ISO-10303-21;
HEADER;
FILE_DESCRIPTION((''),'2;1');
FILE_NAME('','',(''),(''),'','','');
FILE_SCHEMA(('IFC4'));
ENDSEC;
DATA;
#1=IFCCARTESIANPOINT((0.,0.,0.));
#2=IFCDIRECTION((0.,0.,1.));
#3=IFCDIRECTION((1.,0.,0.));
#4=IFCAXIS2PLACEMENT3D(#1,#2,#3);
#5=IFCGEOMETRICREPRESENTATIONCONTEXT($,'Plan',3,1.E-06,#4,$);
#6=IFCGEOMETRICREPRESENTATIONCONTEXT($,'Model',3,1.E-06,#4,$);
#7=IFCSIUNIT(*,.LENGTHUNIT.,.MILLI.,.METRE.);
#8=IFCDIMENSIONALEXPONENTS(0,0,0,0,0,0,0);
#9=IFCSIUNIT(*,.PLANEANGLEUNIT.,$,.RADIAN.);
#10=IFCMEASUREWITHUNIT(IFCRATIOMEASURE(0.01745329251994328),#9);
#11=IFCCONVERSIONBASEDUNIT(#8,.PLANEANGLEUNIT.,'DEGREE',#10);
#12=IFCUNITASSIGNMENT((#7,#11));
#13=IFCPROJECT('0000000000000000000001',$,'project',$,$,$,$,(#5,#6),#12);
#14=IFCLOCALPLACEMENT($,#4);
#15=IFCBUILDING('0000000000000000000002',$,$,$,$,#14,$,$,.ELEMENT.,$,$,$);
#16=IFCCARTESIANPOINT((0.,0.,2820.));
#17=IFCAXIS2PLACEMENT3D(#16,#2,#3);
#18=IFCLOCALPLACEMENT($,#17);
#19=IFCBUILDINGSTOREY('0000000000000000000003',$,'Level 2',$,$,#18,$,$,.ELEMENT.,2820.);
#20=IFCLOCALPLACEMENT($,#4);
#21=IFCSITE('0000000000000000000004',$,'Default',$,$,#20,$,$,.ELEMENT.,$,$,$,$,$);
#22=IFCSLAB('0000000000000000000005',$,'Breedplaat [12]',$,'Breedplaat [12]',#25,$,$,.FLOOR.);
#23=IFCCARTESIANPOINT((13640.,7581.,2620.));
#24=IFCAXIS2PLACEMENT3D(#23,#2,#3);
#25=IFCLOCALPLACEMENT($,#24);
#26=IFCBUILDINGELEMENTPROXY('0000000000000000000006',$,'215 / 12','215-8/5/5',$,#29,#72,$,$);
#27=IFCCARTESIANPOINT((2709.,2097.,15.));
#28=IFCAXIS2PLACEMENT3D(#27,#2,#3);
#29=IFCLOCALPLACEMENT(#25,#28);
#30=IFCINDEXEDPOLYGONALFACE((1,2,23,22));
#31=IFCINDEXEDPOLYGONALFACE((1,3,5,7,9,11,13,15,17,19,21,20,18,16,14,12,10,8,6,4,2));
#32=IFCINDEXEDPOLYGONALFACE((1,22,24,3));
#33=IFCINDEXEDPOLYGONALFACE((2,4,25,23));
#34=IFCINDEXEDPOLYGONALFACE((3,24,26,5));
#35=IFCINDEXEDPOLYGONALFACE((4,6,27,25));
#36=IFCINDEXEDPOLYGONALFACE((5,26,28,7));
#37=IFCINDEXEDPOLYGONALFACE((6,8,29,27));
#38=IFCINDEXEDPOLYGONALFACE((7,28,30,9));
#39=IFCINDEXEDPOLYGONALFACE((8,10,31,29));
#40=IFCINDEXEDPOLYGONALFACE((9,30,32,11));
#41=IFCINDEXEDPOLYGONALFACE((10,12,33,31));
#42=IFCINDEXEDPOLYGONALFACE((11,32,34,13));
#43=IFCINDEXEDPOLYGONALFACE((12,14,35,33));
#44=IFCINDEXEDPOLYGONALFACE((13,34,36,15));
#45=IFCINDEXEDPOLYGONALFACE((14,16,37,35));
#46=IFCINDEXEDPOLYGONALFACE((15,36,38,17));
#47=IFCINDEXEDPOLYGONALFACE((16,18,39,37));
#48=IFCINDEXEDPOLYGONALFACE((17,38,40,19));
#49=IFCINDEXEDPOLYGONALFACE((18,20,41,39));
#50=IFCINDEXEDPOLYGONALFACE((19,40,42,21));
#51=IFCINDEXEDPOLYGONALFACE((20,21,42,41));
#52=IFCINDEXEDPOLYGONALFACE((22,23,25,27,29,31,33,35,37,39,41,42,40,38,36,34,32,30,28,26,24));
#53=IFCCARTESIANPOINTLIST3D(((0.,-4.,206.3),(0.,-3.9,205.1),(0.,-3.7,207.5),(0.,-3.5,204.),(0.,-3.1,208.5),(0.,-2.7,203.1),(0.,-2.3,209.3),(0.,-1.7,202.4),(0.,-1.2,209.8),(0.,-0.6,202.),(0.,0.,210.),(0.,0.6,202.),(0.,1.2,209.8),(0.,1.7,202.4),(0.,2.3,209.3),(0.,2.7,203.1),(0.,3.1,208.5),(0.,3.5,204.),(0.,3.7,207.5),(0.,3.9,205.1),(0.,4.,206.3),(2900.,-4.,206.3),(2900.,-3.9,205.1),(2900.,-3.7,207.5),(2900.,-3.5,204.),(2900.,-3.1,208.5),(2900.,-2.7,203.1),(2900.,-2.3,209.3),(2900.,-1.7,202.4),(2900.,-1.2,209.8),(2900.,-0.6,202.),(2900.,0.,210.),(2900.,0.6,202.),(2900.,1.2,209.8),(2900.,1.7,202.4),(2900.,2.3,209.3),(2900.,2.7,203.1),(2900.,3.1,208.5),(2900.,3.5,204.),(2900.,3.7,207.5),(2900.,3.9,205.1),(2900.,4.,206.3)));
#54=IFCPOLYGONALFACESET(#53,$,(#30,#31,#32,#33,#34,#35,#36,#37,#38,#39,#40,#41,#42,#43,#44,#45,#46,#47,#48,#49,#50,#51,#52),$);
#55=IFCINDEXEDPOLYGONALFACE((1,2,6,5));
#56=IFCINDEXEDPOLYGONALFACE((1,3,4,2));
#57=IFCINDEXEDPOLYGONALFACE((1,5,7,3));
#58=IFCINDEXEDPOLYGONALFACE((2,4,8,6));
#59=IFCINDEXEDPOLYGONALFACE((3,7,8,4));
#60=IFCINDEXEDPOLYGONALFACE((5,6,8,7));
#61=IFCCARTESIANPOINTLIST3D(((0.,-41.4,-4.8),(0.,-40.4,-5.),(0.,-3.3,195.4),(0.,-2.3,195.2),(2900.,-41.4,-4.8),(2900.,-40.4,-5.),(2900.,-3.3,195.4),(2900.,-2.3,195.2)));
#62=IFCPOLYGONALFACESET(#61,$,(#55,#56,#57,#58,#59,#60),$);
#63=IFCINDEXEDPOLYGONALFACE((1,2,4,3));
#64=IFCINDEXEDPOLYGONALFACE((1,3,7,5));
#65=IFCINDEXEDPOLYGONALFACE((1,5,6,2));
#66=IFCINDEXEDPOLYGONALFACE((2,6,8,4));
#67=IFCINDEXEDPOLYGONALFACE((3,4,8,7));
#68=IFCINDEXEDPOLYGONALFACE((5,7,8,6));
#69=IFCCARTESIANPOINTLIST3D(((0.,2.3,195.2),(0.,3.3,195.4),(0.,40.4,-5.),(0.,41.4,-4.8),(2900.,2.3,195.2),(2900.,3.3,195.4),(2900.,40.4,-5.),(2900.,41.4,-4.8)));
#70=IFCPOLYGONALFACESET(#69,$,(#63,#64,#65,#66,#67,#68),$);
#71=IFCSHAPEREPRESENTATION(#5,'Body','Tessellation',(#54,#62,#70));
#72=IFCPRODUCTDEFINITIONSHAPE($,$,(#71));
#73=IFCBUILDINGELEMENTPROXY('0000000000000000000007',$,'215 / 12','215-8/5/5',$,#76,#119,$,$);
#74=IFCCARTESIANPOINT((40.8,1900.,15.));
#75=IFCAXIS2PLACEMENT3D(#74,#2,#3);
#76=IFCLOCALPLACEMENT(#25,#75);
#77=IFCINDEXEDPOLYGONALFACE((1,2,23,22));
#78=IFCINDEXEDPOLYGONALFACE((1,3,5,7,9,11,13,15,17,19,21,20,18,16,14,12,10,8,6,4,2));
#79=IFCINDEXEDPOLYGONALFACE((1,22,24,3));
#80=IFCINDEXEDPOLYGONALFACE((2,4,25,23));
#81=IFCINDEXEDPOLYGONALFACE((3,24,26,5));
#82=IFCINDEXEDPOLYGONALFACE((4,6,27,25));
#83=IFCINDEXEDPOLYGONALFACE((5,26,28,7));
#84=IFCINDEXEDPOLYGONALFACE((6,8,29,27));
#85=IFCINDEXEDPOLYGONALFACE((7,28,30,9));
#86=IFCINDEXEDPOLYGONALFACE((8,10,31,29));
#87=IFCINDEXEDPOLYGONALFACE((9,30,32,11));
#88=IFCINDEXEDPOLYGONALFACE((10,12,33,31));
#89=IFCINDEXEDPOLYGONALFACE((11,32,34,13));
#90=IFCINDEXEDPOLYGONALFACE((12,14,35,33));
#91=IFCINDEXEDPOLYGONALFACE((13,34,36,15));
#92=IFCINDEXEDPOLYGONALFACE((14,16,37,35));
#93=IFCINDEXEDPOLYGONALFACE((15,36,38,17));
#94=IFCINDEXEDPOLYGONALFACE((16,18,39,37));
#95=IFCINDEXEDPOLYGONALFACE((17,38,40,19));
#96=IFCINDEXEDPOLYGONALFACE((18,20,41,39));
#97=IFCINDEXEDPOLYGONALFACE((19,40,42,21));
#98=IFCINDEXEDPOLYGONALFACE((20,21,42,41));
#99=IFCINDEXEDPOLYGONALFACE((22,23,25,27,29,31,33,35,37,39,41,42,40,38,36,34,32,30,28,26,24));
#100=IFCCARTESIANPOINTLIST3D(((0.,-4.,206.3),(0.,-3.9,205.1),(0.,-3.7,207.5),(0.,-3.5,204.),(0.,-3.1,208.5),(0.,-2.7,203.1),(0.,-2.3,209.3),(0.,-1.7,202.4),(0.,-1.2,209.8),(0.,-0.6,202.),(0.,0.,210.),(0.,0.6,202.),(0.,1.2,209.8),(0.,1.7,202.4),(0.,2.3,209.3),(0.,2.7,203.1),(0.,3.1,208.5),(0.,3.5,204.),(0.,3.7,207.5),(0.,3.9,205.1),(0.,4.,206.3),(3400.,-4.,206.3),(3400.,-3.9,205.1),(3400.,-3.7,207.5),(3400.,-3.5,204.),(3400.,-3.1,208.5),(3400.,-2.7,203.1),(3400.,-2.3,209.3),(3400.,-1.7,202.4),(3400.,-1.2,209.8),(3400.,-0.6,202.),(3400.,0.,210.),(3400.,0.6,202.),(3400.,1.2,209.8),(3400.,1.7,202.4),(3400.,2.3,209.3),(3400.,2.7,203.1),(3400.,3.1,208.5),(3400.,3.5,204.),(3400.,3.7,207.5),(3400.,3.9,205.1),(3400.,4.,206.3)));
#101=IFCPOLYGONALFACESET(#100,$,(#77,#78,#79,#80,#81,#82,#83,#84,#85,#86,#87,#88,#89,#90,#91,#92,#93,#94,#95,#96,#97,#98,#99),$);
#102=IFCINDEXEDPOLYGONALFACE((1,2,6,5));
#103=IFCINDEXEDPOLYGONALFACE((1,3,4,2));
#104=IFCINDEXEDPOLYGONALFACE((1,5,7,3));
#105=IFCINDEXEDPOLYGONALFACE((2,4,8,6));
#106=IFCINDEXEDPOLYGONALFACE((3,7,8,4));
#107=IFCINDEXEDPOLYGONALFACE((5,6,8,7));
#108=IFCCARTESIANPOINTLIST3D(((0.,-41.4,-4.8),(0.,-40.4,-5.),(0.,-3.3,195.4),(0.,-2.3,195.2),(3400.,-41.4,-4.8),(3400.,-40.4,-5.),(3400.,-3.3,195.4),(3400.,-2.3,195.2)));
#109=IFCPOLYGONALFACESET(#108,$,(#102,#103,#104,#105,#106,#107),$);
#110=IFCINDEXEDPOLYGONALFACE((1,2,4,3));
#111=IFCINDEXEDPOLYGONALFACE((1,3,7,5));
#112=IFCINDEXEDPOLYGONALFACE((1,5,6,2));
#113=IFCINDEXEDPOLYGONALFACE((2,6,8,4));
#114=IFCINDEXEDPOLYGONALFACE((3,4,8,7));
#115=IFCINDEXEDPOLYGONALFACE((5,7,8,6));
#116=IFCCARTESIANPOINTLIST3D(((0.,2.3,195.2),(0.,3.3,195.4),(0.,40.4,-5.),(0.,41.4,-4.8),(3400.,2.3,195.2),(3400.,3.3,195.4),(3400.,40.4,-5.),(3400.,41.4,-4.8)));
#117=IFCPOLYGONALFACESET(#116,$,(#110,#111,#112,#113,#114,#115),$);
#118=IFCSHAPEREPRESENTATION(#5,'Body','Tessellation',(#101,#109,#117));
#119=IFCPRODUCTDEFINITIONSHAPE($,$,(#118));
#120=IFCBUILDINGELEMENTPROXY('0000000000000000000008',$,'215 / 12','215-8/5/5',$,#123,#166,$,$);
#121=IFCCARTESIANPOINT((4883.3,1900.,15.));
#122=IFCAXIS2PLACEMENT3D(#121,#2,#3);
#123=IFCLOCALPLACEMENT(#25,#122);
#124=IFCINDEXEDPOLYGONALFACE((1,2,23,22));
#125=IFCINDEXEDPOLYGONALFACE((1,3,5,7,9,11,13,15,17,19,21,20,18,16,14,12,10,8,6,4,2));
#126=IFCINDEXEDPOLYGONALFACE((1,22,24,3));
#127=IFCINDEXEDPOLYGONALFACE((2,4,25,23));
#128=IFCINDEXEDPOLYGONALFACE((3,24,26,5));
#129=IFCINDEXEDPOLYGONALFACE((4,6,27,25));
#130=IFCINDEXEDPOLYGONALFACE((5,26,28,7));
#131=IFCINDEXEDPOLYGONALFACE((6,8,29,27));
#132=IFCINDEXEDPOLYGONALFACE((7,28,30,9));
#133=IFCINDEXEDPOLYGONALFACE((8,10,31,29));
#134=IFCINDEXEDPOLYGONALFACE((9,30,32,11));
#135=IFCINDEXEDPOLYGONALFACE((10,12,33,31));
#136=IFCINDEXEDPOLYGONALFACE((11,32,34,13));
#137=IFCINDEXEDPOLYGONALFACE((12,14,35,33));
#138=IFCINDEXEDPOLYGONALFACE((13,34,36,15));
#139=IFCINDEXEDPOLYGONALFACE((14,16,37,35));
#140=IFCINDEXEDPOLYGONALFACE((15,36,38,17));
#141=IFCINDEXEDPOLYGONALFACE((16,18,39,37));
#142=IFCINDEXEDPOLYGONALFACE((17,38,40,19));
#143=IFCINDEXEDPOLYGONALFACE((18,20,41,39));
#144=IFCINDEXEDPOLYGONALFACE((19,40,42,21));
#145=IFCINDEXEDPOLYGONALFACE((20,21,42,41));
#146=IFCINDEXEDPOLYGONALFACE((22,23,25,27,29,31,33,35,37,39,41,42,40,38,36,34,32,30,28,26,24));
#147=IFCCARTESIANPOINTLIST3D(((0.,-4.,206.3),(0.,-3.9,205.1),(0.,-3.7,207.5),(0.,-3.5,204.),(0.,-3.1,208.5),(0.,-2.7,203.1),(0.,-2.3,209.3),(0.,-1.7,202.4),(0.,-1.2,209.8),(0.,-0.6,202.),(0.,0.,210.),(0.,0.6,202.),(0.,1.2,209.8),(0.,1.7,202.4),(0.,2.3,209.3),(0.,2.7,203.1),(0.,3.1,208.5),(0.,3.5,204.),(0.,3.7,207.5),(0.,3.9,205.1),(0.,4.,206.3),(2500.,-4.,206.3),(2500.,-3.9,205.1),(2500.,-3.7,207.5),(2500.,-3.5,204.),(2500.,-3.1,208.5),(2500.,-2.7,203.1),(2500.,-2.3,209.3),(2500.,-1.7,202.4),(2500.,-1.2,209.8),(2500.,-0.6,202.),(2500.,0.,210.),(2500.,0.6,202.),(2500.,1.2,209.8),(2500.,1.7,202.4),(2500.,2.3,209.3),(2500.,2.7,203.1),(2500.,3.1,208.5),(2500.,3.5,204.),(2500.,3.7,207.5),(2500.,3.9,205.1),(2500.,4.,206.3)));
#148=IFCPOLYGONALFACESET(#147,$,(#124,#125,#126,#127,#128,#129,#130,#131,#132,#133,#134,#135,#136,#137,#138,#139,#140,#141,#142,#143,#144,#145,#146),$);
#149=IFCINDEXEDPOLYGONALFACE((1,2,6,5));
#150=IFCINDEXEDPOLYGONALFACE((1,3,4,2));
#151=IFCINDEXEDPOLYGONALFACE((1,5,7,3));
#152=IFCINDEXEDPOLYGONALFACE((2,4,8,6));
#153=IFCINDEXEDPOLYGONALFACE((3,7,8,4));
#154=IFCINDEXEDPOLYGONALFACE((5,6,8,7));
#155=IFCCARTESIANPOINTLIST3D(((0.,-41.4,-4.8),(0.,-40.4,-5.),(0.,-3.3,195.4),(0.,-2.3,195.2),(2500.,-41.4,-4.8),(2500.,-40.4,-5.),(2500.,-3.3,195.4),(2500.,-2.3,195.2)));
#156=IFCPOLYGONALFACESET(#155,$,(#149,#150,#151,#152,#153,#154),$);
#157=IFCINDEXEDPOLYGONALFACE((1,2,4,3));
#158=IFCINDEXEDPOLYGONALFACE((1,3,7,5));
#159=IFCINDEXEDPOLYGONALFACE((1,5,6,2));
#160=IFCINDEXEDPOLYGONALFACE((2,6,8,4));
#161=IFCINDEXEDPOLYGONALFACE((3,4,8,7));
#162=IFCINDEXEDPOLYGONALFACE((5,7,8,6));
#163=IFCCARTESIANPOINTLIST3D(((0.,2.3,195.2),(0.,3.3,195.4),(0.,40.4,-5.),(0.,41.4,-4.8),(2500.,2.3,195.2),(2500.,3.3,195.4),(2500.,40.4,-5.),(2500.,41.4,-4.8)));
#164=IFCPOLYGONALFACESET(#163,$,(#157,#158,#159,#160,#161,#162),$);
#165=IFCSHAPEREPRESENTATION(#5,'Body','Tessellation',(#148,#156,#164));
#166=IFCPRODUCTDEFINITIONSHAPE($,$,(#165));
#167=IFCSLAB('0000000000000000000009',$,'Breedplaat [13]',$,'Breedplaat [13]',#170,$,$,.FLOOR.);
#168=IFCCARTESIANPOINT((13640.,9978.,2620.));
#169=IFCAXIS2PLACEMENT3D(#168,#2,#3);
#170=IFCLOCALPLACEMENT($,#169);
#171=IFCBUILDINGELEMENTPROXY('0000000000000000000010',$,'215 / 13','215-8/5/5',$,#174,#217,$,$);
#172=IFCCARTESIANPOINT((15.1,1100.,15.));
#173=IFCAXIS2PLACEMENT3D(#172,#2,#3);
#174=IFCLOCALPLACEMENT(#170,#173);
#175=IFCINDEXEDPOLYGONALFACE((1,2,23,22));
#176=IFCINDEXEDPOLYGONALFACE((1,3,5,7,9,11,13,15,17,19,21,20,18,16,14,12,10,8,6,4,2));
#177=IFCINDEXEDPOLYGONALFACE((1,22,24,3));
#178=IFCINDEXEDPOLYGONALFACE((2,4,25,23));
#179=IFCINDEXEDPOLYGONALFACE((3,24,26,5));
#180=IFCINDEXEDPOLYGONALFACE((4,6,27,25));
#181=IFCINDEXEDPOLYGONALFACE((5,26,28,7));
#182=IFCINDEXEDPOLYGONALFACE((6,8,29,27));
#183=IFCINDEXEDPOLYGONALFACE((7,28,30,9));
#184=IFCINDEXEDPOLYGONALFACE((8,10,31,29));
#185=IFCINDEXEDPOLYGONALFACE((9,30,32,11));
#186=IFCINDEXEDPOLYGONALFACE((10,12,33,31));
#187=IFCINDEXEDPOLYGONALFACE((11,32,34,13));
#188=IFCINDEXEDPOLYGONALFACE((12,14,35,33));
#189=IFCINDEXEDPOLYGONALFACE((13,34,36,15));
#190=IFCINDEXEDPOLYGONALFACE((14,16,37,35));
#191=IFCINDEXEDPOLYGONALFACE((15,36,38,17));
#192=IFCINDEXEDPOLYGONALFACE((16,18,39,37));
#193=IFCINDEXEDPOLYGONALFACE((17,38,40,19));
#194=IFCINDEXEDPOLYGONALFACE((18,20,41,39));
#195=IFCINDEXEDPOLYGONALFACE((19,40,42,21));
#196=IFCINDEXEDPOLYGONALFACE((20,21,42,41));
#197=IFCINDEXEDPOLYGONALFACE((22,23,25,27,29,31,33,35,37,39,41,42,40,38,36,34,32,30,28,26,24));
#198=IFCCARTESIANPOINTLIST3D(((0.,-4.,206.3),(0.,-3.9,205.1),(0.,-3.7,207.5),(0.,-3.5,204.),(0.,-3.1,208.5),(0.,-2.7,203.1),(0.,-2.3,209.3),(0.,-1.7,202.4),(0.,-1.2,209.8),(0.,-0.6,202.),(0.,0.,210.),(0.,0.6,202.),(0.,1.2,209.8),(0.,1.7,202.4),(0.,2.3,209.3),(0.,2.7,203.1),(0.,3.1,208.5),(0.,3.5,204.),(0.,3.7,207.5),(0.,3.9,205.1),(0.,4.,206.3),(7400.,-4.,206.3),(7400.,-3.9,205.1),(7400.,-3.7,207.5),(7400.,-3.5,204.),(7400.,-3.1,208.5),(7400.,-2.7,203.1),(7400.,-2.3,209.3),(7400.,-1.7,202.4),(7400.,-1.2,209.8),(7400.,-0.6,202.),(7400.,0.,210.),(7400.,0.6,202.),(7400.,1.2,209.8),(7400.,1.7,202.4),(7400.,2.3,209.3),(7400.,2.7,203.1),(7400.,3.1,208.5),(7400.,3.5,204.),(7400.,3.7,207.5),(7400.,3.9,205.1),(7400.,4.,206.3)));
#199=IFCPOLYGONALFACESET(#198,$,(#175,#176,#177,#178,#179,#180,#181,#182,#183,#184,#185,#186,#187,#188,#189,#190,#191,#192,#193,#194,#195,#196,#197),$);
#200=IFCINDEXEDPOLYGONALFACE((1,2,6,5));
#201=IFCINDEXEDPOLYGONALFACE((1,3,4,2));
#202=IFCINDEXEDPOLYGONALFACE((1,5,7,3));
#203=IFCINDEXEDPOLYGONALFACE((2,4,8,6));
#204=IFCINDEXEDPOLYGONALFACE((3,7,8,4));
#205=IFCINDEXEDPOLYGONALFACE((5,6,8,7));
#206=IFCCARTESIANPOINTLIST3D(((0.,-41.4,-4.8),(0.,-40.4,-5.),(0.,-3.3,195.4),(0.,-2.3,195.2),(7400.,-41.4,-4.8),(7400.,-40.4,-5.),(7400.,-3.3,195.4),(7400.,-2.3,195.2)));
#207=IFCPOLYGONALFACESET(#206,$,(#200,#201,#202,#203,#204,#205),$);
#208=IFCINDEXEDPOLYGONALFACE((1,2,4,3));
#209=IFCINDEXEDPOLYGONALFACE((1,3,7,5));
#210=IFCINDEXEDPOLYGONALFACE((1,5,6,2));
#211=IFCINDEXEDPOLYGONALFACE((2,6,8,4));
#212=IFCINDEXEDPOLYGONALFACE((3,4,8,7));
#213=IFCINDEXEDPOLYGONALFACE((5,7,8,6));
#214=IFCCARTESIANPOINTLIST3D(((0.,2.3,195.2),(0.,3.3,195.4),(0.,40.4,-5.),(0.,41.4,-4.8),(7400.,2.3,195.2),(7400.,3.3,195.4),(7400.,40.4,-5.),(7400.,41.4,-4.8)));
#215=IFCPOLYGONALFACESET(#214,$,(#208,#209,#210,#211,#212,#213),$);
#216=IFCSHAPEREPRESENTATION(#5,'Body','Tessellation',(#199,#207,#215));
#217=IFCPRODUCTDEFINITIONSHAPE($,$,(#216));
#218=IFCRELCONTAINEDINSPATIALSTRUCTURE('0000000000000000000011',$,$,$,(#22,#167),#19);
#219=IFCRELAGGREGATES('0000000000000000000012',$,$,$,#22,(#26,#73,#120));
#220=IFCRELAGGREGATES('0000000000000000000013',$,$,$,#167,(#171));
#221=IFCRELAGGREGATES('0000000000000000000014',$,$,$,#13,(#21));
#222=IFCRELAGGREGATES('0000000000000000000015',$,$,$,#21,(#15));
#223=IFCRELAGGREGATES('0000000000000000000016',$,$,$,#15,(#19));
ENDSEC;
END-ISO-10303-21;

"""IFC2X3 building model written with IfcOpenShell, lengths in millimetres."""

from ifc_helpers import new_model, entity, si_unit, converted_unit, frame, origin_with_axes, origin_2d_with_axis, place, context, project, spatial, rectangle, circle, extrude, element, aggregate, save


model = new_model("IFC2X3")

# Units and contexts
plan_context = context("Plan", 3, precision=1e-06, world=origin_with_axes())
model_context = context("Model", 3, precision=1e-06, world=origin_with_axes())
ifc_project = project(units=[si_unit("LENGTHUNIT", "METRE", prefix="MILLI"), converted_unit("PLANEANGLEUNIT", "DEGREE", entity("IfcRatioMeasure", 0.01745329251994328), si_unit("PLANEANGLEUNIT", "RADIAN"), dimensions=[0, 0, 0, 0, 0, 0, 0])], contexts=[plan_context, model_context])

# Site, building, storey
site_placement = place(None, origin_with_axes())
site = spatial("IfcSite", under=ifc_project, at=site_placement, Name="Default", CompositionType="ELEMENT")
building_placement = place(None, origin_with_axes())
building = spatial("IfcBuilding", under=site, at=building_placement, CompositionType="ELEMENT")
storey_placement = place(None, frame((0.0, 0.0, 2820.0), z_axis=(0.0, 0.0, 1.0), x_axis=(1.0, 0.0, 0.0)))
storey = spatial("IfcBuildingStorey", under=building, at=storey_placement, Name="Level 2", CompositionType="ELEMENT", Elevation=2820.0)

# Slab, building element proxies
slab_1_placement = place(None, frame((13640.0, 7581.0, 2620.0), z_axis=(0.0, 0.0, 1.0), x_axis=(1.0, 0.0, 0.0)))
slab_1 = element("IfcSlab", 1, at=slab_1_placement, inside=storey, Name="Breedplaat [12]", ObjectType="Breedplaat [12]", PredefinedType="FLOOR")
proxy_1_placement = place(slab_1_placement, frame((2709.0, 2097.0, 15.0), z_axis=(0.0, 0.0, 1.0), x_axis=(1.0, 0.0, 0.0)))
proxy_1 = element("IfcBuildingElementProxy", 2, at=proxy_1_placement, Name="215 / 12", Description="215-8/5/5", context=plan_context, shape_type="SweptSolid", body=[
    extrude(circle(Radius=4.0, at=origin_2d_with_axis()), frame((0.0, 0.0, 206.0), z_axis=(1.0, 0.0, 0.0), x_axis=(0.0, 0.0, 1.0)), (0.0, 0.0, 1.0), 2900.0),
    extrude(rectangle(XDim=203.8, YDim=1.0, at=origin_2d_with_axis()), frame((0.0, -21.9, 95.2), z_axis=(1.0, 0.0, 0.0), x_axis=(0.0, 0.187112, 0.982339)), (0.0, 0.0, 1.0), 2900.0),
    extrude(rectangle(XDim=203.8, YDim=1.0, at=origin_2d_with_axis()), frame((0.0, 21.9, 95.2), z_axis=(1.0, 0.0, 0.0), x_axis=(0.0, -0.187112, 0.982339)), (0.0, 0.0, 1.0), 2900.0),
])
proxy_2_placement = place(slab_1_placement, frame((40.8, 1900.0, 15.0), z_axis=(0.0, 0.0, 1.0), x_axis=(1.0, 0.0, 0.0)))
proxy_2 = element("IfcBuildingElementProxy", 3, at=proxy_2_placement, Name="215 / 12", Description="215-8/5/5", context=plan_context, shape_type="SweptSolid", body=[
    extrude(circle(Radius=4.0, at=origin_2d_with_axis()), frame((0.0, 0.0, 206.0), z_axis=(1.0, 0.0, 0.0), x_axis=(0.0, 0.0, 1.0)), (0.0, 0.0, 1.0), 3400.0),
    extrude(rectangle(XDim=203.8, YDim=1.0, at=origin_2d_with_axis()), frame((0.0, -21.9, 95.2), z_axis=(1.0, 0.0, 0.0), x_axis=(0.0, 0.187112, 0.982339)), (0.0, 0.0, 1.0), 3400.0),
    extrude(rectangle(XDim=203.8, YDim=1.0, at=origin_2d_with_axis()), frame((0.0, 21.9, 95.2), z_axis=(1.0, 0.0, 0.0), x_axis=(0.0, -0.187112, 0.982339)), (0.0, 0.0, 1.0), 3400.0),
])
proxy_3_placement = place(slab_1_placement, frame((4883.3, 1900.0, 15.0), z_axis=(0.0, 0.0, 1.0), x_axis=(1.0, 0.0, 0.0)))
proxy_3 = element("IfcBuildingElementProxy", 4, at=proxy_3_placement, Name="215 / 12", Description="215-8/5/5", context=plan_context, shape_type="SweptSolid", body=[
    extrude(circle(Radius=4.0, at=origin_2d_with_axis()), frame((0.0, 0.0, 206.0), z_axis=(1.0, 0.0, 0.0), x_axis=(0.0, 0.0, 1.0)), (0.0, 0.0, 1.0), 2500.0),
    extrude(rectangle(XDim=203.8, YDim=1.0, at=origin_2d_with_axis()), frame((0.0, -21.9, 95.2), z_axis=(1.0, 0.0, 0.0), x_axis=(0.0, 0.187112, 0.982339)), (0.0, 0.0, 1.0), 2500.0),
    extrude(rectangle(XDim=203.8, YDim=1.0, at=origin_2d_with_axis()), frame((0.0, 21.9, 95.2), z_axis=(1.0, 0.0, 0.0), x_axis=(0.0, -0.187112, 0.982339)), (0.0, 0.0, 1.0), 2500.0),
])
aggregate(slab_1, [proxy_1, proxy_2, proxy_3])

# Slab, building element proxy
slab_2_placement = place(None, frame((13640.0, 9978.0, 2620.0), z_axis=(0.0, 0.0, 1.0), x_axis=(1.0, 0.0, 0.0)))
slab_2 = element("IfcSlab", 5, at=slab_2_placement, inside=storey, Name="Breedplaat [13]", ObjectType="Breedplaat [13]", PredefinedType="FLOOR")
proxy_4_placement = place(slab_2_placement, frame((15.1, 1100.0, 15.0), z_axis=(0.0, 0.0, 1.0), x_axis=(1.0, 0.0, 0.0)))
proxy_4 = element("IfcBuildingElementProxy", 6, at=proxy_4_placement, Name="215 / 13", Description="215-8/5/5", context=plan_context, shape_type="SweptSolid", body=[
    extrude(circle(Radius=4.0, at=origin_2d_with_axis()), frame((0.0, 0.0, 206.0), z_axis=(1.0, 0.0, 0.0), x_axis=(0.0, 0.0, 1.0)), (0.0, 0.0, 1.0), 7400.0),
    extrude(rectangle(XDim=203.8, YDim=1.0, at=origin_2d_with_axis()), frame((0.0, -21.9, 95.2), z_axis=(1.0, 0.0, 0.0), x_axis=(0.0, 0.187112, 0.982339)), (0.0, 0.0, 1.0), 7400.0),
    extrude(rectangle(XDim=203.8, YDim=1.0, at=origin_2d_with_axis()), frame((0.0, 21.9, 95.2), z_axis=(1.0, 0.0, 0.0), x_axis=(0.0, -0.187112, 0.982339)), (0.0, 0.0, 1.0), 7400.0),
])
aggregate(slab_2, [proxy_4])

save(model, "model.ifc")
